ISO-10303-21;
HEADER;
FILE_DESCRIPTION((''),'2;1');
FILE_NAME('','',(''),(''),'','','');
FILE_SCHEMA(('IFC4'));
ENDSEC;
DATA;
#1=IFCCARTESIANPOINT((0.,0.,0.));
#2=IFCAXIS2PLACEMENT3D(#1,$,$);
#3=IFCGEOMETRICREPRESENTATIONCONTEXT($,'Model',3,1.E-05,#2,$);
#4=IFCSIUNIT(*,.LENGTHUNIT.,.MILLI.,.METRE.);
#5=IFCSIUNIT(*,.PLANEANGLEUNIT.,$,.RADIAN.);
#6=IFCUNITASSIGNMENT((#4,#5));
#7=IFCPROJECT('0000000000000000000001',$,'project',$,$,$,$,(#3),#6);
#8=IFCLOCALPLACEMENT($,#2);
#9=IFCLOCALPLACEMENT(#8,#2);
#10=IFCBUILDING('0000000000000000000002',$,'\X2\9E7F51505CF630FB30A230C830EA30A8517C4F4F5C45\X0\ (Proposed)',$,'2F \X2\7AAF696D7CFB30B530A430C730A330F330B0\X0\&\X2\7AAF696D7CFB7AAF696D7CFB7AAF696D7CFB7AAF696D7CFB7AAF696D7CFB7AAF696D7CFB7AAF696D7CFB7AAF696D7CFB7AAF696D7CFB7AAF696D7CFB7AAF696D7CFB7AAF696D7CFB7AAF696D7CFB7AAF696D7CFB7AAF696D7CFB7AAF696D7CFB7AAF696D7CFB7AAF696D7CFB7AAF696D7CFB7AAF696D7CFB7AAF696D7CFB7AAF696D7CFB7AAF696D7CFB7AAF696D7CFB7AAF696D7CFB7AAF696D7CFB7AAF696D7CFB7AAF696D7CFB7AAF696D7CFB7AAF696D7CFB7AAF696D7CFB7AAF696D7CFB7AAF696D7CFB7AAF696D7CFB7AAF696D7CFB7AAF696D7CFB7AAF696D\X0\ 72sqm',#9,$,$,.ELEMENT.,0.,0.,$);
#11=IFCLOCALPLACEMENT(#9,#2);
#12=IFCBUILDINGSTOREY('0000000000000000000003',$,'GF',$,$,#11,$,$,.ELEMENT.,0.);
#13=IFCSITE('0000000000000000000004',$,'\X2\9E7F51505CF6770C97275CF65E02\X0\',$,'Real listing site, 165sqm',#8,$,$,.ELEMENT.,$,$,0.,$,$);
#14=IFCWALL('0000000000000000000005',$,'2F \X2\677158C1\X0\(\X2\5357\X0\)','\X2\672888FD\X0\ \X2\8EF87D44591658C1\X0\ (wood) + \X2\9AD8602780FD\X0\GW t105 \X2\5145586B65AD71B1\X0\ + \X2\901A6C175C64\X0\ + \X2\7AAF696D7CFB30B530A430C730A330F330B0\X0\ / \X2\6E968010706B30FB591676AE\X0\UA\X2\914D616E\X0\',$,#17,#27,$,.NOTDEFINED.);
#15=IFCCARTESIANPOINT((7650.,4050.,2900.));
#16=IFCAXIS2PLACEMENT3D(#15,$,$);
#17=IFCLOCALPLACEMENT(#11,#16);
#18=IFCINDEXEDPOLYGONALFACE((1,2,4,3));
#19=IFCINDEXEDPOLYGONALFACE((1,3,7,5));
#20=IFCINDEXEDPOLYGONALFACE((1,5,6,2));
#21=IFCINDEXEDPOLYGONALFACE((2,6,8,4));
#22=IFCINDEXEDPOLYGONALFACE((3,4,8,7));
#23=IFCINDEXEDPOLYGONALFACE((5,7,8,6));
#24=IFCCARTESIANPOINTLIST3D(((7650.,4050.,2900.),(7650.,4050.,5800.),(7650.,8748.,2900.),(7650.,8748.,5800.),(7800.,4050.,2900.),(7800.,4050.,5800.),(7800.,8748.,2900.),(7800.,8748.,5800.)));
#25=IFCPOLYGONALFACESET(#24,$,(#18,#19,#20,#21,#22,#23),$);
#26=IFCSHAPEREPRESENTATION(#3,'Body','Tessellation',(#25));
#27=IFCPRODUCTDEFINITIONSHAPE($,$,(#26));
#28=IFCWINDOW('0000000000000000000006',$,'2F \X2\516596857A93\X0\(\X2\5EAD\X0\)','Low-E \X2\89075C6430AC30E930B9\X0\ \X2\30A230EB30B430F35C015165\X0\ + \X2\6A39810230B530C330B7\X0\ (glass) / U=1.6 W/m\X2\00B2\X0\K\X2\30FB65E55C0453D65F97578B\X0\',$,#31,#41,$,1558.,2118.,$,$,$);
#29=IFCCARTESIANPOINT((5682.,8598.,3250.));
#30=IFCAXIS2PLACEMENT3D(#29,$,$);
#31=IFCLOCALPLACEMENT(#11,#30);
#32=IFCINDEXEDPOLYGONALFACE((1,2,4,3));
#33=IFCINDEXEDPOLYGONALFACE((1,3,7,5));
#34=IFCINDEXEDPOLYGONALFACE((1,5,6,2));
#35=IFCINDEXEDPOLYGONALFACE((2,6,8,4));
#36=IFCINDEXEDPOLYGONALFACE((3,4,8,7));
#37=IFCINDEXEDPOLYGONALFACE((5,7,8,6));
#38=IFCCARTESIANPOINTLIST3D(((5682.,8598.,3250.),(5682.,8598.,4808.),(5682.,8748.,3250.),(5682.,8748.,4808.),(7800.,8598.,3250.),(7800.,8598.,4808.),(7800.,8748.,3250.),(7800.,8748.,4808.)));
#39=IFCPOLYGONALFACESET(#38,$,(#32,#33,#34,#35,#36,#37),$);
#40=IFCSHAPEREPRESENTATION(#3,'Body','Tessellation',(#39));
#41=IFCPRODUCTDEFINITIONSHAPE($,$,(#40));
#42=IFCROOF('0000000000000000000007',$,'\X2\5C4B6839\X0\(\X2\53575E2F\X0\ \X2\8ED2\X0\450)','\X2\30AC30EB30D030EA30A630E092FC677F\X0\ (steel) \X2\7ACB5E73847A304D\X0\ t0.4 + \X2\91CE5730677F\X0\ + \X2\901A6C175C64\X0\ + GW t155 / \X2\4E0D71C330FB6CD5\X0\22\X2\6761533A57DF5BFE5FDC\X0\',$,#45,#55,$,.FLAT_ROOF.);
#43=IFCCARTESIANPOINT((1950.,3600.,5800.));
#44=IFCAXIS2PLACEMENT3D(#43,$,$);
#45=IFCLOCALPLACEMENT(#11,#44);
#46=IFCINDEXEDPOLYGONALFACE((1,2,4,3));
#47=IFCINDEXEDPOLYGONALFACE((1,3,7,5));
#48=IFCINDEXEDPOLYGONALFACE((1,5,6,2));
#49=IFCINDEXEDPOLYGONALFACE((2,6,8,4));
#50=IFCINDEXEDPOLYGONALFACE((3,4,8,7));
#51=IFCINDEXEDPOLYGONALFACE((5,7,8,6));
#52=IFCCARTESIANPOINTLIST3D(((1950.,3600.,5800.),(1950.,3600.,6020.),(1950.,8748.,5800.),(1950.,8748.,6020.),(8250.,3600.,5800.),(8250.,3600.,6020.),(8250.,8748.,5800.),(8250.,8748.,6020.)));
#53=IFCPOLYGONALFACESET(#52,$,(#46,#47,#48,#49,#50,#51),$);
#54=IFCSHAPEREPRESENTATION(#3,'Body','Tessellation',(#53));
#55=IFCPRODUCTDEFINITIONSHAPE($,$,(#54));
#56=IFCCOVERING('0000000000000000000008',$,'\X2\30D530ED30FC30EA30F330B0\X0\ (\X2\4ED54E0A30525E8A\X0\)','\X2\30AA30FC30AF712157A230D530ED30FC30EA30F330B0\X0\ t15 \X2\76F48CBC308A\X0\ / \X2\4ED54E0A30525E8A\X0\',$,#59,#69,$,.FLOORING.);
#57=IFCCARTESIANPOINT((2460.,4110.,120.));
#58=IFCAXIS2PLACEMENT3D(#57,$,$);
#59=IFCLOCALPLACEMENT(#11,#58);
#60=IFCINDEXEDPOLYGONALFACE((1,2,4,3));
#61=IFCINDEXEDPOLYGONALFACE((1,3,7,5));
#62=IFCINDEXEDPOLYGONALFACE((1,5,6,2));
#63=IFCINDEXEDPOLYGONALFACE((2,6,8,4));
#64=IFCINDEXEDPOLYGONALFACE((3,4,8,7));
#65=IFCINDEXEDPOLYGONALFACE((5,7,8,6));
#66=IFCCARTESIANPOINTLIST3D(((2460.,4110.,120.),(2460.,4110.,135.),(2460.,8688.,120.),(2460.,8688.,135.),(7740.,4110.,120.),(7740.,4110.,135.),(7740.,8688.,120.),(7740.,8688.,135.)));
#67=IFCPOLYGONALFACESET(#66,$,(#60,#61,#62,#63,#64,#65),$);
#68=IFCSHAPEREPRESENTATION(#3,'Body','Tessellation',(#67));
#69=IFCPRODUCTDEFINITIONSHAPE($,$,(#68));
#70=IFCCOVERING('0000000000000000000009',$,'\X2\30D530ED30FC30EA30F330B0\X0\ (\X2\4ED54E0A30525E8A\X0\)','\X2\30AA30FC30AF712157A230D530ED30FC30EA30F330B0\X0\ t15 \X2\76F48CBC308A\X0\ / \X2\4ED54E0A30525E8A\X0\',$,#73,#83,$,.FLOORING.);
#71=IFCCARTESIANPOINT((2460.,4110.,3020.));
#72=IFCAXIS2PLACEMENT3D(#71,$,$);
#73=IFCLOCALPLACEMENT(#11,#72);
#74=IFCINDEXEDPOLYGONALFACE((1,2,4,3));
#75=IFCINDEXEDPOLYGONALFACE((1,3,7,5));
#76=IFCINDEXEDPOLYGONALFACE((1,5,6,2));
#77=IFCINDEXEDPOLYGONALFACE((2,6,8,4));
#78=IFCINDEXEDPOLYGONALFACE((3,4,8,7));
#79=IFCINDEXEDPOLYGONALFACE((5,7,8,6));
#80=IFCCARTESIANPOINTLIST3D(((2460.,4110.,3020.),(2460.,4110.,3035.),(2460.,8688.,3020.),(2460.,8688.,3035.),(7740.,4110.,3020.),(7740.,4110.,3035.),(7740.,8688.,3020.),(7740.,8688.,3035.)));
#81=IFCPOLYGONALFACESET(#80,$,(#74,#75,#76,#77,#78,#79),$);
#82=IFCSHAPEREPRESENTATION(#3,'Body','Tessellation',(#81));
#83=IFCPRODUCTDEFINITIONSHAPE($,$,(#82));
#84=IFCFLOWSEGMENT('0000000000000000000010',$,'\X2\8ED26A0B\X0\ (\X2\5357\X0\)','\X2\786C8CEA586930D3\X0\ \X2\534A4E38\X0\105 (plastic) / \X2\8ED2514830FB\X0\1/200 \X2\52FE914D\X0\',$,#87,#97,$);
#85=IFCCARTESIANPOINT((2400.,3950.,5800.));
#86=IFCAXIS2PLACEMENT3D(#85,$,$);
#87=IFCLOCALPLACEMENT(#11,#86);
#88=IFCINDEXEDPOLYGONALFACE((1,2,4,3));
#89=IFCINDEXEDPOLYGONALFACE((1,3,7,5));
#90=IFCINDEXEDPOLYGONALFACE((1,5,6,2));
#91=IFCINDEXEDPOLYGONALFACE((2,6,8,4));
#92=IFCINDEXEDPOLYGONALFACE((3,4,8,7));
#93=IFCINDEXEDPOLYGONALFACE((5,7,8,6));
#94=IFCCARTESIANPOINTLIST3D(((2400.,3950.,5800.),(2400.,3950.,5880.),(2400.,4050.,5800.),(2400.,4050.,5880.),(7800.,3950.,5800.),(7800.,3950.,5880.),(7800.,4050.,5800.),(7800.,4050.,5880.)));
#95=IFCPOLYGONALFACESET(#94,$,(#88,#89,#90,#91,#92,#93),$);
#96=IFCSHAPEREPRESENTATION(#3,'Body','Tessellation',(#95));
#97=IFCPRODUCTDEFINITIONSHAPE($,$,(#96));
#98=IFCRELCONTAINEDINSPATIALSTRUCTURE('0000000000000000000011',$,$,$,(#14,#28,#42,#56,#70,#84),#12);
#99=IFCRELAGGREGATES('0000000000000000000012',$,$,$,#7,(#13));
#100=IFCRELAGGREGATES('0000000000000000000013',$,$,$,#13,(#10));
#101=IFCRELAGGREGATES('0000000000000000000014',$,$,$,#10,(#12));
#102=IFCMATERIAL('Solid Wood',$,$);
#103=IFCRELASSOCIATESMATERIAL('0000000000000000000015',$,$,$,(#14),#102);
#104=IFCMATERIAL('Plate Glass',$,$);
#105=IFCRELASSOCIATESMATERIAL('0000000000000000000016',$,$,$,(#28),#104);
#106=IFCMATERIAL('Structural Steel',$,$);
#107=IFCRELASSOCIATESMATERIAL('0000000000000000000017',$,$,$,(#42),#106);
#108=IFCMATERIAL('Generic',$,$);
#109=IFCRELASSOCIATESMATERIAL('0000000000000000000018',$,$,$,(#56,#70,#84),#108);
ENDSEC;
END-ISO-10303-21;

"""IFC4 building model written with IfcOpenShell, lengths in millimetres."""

from ifc_helpers import new_model, si_unit, frame, frame_2d, origin, place, context, project, spatial, rectangle, extrude, material, element, fill, save


model = new_model("IFC4")

# Units and contexts
model_context = context("Model", 3, precision=1e-05, world=origin())
ifc_project = project(units=[si_unit("LENGTHUNIT", "METRE", prefix="MILLI"), si_unit("PLANEANGLEUNIT", "RADIAN")], contexts=[model_context])

# Site, building, storey
site_placement = place(None, origin())
site = spatial("IfcSite", under=ifc_project, at=site_placement, Name="鹿児島県霧島市", ObjectType="Real listing site, 165sqm", CompositionType="ELEMENT", RefElevation=0.0)
building_placement = place(site_placement, origin())
building = spatial("IfcBuilding", under=site, at=building_placement, Name="鹿児島・アトリエ兼住居 (Proposed)", ObjectType="2F 窯業系サイディング&窯業系窯業系窯業系窯業系窯業系窯業系窯業系窯業系窯業系窯業系窯業系窯業系窯業系窯業系窯業系窯業系窯業系窯業系窯業系窯業系窯業系窯業系窯業系窯業系窯業系窯業系窯業系窯業系窯業系窯業系窯業系窯業系窯業系窯業系窯業系窯業系窯業 72sqm", CompositionType="ELEMENT", ElevationOfRefHeight=0.0, ElevationOfTerrain=0.0)
storey_placement = place(building_placement, origin())
storey = spatial("IfcBuildingStorey", under=building, at=storey_placement, Name="GF", CompositionType="ELEMENT", Elevation=0.0)

# Shared definitions
ifc_material_1 = material(Name="Solid Wood")

# Wall, opening, window
ifc_material_2 = material(Name="Plate Glass")
wall_1_placement = place(storey_placement, frame((7650.0, 4050.0, 2900.0)))
wall_1 = element("IfcWall", 1, at=wall_1_placement, inside=storey, material=ifc_material_1, Name="2F 東壁(南)", Description="木製 軸組外壁 (wood) + 高性能GW t105 充填断熱 + 通気層 + 窯業系サイディング / 準耐火・外皮UA配慮", PredefinedType="NOTDEFINED", context=model_context, shape_type="SweptSolid", body=[
    extrude(rectangle(XDim=150.0, YDim=4698.0, at=frame_2d((75.0, 2349.0))), frame((7650.0, 4050.0, 2900.0)), (0.0, 0.0, 1.0), 2900.0),
])
opening_1_placement = place(storey_placement, frame((5682.0, 8598.0, 3250.0)))
opening_1 = element("IfcOpeningElement", 2, at=opening_1_placement, cuts=wall_1, PredefinedType="NOTDEFINED", context=model_context, shape_type="SweptSolid", body=[
    extrude(rectangle(XDim=2118.0, YDim=150.0, at=frame_2d((1059.0, 75.0))), frame((5682.0, 8598.0, 3250.0)), (0.0, 0.0, 1.0), 1558.0),
])
window_1_placement = place(storey_placement, frame((5682.0, 8598.0, 3250.0)))
window_1 = element("IfcWindow", 3, at=window_1_placement, inside=storey, material=ifc_material_2, Name="2F 入隅窓(庭)", Description="Low-E 複層ガラス アルゴン封入 + 樹脂サッシ (glass) / U=1.6 W/m²K・日射取得型", OverallHeight=1558.0, OverallWidth=2118.0, context=model_context, shape_type="SweptSolid", body=[
    extrude(rectangle(XDim=2118.0, YDim=150.0, at=frame_2d((1059.0, 75.0))), frame((5682.0, 8598.0, 3250.0)), (0.0, 0.0, 1.0), 1558.0),
])
fill(opening_1, window_1)

# Roof
ifc_material_3 = material(Name="Structural Steel")
for number, where, name in (
    (4, (1950.0, 3600.0, 5800.0), "屋根(南帯 軒450)"),
):
    element("IfcRoof", number, at=place(storey_placement, frame(where)), inside=storey, material=ifc_material_3, Name=name, Description="ガルバリウム鋼板 (steel) 立平葺き t0.4 + 野地板 + 通気層 + GW t155 / 不燃・法22条区域対応", PredefinedType="FLAT_ROOF", context=model_context, shape_type="SweptSolid", body=[
        extrude(rectangle(XDim=6300.0, YDim=5148.0, at=frame_2d((3150.0, 2574.0))), frame((1950.0, 3600.0, 5800.0)), (0.0, 0.0, 1.0), 220.0),
    ])

# Coverings
ifc_material_4 = material(Name="Generic")
covering_1_placement = place(storey_placement, frame((2460.0, 4110.0, 120.0)))
element("IfcCovering", 5, at=covering_1_placement, inside=storey, material=ifc_material_4, Name="フローリング (仕上げ床)", Description="オーク無垢フローリング t15 直貼り / 仕上げ床", PredefinedType="FLOORING", context=model_context, shape_type="SweptSolid", body=[
    extrude(rectangle(XDim=5280.0, YDim=4578.0, at=frame_2d((2640.0, 2289.0))), frame((2460.0, 4110.0, 120.0)), (0.0, 0.0, 1.0), 15.0),
])
covering_2_placement = place(storey_placement, frame((2460.0, 4110.0, 3020.0)))
element("IfcCovering", 6, at=covering_2_placement, inside=storey, material=ifc_material_4, Name="フローリング (仕上げ床)", Description="オーク無垢フローリング t15 直貼り / 仕上げ床", PredefinedType="FLOORING", context=model_context, shape_type="SweptSolid", body=[
    extrude(rectangle(XDim=5280.0, YDim=4578.0, at=frame_2d((2640.0, 2289.0))), frame((2460.0, 4110.0, 3020.0)), (0.0, 0.0, 1.0), 15.0),
])

# Flow segment
flow_segment_placement = place(storey_placement, frame((2400.0, 3950.0, 5800.0)))
element("IfcFlowSegment", 7, at=flow_segment_placement, inside=storey, material=ifc_material_4, Name="軒樋 (南)", Description="硬質塩ビ 半丸105 (plastic) / 軒先・1/200 勾配", context=model_context, shape_type="SweptSolid", body=[
    extrude(rectangle(XDim=5400.0, YDim=100.0, at=frame_2d((2700.0, 50.0))), frame((2400.0, 3950.0, 5800.0)), (0.0, 0.0, 1.0), 80.0),
])

save(model, "model.ifc")
